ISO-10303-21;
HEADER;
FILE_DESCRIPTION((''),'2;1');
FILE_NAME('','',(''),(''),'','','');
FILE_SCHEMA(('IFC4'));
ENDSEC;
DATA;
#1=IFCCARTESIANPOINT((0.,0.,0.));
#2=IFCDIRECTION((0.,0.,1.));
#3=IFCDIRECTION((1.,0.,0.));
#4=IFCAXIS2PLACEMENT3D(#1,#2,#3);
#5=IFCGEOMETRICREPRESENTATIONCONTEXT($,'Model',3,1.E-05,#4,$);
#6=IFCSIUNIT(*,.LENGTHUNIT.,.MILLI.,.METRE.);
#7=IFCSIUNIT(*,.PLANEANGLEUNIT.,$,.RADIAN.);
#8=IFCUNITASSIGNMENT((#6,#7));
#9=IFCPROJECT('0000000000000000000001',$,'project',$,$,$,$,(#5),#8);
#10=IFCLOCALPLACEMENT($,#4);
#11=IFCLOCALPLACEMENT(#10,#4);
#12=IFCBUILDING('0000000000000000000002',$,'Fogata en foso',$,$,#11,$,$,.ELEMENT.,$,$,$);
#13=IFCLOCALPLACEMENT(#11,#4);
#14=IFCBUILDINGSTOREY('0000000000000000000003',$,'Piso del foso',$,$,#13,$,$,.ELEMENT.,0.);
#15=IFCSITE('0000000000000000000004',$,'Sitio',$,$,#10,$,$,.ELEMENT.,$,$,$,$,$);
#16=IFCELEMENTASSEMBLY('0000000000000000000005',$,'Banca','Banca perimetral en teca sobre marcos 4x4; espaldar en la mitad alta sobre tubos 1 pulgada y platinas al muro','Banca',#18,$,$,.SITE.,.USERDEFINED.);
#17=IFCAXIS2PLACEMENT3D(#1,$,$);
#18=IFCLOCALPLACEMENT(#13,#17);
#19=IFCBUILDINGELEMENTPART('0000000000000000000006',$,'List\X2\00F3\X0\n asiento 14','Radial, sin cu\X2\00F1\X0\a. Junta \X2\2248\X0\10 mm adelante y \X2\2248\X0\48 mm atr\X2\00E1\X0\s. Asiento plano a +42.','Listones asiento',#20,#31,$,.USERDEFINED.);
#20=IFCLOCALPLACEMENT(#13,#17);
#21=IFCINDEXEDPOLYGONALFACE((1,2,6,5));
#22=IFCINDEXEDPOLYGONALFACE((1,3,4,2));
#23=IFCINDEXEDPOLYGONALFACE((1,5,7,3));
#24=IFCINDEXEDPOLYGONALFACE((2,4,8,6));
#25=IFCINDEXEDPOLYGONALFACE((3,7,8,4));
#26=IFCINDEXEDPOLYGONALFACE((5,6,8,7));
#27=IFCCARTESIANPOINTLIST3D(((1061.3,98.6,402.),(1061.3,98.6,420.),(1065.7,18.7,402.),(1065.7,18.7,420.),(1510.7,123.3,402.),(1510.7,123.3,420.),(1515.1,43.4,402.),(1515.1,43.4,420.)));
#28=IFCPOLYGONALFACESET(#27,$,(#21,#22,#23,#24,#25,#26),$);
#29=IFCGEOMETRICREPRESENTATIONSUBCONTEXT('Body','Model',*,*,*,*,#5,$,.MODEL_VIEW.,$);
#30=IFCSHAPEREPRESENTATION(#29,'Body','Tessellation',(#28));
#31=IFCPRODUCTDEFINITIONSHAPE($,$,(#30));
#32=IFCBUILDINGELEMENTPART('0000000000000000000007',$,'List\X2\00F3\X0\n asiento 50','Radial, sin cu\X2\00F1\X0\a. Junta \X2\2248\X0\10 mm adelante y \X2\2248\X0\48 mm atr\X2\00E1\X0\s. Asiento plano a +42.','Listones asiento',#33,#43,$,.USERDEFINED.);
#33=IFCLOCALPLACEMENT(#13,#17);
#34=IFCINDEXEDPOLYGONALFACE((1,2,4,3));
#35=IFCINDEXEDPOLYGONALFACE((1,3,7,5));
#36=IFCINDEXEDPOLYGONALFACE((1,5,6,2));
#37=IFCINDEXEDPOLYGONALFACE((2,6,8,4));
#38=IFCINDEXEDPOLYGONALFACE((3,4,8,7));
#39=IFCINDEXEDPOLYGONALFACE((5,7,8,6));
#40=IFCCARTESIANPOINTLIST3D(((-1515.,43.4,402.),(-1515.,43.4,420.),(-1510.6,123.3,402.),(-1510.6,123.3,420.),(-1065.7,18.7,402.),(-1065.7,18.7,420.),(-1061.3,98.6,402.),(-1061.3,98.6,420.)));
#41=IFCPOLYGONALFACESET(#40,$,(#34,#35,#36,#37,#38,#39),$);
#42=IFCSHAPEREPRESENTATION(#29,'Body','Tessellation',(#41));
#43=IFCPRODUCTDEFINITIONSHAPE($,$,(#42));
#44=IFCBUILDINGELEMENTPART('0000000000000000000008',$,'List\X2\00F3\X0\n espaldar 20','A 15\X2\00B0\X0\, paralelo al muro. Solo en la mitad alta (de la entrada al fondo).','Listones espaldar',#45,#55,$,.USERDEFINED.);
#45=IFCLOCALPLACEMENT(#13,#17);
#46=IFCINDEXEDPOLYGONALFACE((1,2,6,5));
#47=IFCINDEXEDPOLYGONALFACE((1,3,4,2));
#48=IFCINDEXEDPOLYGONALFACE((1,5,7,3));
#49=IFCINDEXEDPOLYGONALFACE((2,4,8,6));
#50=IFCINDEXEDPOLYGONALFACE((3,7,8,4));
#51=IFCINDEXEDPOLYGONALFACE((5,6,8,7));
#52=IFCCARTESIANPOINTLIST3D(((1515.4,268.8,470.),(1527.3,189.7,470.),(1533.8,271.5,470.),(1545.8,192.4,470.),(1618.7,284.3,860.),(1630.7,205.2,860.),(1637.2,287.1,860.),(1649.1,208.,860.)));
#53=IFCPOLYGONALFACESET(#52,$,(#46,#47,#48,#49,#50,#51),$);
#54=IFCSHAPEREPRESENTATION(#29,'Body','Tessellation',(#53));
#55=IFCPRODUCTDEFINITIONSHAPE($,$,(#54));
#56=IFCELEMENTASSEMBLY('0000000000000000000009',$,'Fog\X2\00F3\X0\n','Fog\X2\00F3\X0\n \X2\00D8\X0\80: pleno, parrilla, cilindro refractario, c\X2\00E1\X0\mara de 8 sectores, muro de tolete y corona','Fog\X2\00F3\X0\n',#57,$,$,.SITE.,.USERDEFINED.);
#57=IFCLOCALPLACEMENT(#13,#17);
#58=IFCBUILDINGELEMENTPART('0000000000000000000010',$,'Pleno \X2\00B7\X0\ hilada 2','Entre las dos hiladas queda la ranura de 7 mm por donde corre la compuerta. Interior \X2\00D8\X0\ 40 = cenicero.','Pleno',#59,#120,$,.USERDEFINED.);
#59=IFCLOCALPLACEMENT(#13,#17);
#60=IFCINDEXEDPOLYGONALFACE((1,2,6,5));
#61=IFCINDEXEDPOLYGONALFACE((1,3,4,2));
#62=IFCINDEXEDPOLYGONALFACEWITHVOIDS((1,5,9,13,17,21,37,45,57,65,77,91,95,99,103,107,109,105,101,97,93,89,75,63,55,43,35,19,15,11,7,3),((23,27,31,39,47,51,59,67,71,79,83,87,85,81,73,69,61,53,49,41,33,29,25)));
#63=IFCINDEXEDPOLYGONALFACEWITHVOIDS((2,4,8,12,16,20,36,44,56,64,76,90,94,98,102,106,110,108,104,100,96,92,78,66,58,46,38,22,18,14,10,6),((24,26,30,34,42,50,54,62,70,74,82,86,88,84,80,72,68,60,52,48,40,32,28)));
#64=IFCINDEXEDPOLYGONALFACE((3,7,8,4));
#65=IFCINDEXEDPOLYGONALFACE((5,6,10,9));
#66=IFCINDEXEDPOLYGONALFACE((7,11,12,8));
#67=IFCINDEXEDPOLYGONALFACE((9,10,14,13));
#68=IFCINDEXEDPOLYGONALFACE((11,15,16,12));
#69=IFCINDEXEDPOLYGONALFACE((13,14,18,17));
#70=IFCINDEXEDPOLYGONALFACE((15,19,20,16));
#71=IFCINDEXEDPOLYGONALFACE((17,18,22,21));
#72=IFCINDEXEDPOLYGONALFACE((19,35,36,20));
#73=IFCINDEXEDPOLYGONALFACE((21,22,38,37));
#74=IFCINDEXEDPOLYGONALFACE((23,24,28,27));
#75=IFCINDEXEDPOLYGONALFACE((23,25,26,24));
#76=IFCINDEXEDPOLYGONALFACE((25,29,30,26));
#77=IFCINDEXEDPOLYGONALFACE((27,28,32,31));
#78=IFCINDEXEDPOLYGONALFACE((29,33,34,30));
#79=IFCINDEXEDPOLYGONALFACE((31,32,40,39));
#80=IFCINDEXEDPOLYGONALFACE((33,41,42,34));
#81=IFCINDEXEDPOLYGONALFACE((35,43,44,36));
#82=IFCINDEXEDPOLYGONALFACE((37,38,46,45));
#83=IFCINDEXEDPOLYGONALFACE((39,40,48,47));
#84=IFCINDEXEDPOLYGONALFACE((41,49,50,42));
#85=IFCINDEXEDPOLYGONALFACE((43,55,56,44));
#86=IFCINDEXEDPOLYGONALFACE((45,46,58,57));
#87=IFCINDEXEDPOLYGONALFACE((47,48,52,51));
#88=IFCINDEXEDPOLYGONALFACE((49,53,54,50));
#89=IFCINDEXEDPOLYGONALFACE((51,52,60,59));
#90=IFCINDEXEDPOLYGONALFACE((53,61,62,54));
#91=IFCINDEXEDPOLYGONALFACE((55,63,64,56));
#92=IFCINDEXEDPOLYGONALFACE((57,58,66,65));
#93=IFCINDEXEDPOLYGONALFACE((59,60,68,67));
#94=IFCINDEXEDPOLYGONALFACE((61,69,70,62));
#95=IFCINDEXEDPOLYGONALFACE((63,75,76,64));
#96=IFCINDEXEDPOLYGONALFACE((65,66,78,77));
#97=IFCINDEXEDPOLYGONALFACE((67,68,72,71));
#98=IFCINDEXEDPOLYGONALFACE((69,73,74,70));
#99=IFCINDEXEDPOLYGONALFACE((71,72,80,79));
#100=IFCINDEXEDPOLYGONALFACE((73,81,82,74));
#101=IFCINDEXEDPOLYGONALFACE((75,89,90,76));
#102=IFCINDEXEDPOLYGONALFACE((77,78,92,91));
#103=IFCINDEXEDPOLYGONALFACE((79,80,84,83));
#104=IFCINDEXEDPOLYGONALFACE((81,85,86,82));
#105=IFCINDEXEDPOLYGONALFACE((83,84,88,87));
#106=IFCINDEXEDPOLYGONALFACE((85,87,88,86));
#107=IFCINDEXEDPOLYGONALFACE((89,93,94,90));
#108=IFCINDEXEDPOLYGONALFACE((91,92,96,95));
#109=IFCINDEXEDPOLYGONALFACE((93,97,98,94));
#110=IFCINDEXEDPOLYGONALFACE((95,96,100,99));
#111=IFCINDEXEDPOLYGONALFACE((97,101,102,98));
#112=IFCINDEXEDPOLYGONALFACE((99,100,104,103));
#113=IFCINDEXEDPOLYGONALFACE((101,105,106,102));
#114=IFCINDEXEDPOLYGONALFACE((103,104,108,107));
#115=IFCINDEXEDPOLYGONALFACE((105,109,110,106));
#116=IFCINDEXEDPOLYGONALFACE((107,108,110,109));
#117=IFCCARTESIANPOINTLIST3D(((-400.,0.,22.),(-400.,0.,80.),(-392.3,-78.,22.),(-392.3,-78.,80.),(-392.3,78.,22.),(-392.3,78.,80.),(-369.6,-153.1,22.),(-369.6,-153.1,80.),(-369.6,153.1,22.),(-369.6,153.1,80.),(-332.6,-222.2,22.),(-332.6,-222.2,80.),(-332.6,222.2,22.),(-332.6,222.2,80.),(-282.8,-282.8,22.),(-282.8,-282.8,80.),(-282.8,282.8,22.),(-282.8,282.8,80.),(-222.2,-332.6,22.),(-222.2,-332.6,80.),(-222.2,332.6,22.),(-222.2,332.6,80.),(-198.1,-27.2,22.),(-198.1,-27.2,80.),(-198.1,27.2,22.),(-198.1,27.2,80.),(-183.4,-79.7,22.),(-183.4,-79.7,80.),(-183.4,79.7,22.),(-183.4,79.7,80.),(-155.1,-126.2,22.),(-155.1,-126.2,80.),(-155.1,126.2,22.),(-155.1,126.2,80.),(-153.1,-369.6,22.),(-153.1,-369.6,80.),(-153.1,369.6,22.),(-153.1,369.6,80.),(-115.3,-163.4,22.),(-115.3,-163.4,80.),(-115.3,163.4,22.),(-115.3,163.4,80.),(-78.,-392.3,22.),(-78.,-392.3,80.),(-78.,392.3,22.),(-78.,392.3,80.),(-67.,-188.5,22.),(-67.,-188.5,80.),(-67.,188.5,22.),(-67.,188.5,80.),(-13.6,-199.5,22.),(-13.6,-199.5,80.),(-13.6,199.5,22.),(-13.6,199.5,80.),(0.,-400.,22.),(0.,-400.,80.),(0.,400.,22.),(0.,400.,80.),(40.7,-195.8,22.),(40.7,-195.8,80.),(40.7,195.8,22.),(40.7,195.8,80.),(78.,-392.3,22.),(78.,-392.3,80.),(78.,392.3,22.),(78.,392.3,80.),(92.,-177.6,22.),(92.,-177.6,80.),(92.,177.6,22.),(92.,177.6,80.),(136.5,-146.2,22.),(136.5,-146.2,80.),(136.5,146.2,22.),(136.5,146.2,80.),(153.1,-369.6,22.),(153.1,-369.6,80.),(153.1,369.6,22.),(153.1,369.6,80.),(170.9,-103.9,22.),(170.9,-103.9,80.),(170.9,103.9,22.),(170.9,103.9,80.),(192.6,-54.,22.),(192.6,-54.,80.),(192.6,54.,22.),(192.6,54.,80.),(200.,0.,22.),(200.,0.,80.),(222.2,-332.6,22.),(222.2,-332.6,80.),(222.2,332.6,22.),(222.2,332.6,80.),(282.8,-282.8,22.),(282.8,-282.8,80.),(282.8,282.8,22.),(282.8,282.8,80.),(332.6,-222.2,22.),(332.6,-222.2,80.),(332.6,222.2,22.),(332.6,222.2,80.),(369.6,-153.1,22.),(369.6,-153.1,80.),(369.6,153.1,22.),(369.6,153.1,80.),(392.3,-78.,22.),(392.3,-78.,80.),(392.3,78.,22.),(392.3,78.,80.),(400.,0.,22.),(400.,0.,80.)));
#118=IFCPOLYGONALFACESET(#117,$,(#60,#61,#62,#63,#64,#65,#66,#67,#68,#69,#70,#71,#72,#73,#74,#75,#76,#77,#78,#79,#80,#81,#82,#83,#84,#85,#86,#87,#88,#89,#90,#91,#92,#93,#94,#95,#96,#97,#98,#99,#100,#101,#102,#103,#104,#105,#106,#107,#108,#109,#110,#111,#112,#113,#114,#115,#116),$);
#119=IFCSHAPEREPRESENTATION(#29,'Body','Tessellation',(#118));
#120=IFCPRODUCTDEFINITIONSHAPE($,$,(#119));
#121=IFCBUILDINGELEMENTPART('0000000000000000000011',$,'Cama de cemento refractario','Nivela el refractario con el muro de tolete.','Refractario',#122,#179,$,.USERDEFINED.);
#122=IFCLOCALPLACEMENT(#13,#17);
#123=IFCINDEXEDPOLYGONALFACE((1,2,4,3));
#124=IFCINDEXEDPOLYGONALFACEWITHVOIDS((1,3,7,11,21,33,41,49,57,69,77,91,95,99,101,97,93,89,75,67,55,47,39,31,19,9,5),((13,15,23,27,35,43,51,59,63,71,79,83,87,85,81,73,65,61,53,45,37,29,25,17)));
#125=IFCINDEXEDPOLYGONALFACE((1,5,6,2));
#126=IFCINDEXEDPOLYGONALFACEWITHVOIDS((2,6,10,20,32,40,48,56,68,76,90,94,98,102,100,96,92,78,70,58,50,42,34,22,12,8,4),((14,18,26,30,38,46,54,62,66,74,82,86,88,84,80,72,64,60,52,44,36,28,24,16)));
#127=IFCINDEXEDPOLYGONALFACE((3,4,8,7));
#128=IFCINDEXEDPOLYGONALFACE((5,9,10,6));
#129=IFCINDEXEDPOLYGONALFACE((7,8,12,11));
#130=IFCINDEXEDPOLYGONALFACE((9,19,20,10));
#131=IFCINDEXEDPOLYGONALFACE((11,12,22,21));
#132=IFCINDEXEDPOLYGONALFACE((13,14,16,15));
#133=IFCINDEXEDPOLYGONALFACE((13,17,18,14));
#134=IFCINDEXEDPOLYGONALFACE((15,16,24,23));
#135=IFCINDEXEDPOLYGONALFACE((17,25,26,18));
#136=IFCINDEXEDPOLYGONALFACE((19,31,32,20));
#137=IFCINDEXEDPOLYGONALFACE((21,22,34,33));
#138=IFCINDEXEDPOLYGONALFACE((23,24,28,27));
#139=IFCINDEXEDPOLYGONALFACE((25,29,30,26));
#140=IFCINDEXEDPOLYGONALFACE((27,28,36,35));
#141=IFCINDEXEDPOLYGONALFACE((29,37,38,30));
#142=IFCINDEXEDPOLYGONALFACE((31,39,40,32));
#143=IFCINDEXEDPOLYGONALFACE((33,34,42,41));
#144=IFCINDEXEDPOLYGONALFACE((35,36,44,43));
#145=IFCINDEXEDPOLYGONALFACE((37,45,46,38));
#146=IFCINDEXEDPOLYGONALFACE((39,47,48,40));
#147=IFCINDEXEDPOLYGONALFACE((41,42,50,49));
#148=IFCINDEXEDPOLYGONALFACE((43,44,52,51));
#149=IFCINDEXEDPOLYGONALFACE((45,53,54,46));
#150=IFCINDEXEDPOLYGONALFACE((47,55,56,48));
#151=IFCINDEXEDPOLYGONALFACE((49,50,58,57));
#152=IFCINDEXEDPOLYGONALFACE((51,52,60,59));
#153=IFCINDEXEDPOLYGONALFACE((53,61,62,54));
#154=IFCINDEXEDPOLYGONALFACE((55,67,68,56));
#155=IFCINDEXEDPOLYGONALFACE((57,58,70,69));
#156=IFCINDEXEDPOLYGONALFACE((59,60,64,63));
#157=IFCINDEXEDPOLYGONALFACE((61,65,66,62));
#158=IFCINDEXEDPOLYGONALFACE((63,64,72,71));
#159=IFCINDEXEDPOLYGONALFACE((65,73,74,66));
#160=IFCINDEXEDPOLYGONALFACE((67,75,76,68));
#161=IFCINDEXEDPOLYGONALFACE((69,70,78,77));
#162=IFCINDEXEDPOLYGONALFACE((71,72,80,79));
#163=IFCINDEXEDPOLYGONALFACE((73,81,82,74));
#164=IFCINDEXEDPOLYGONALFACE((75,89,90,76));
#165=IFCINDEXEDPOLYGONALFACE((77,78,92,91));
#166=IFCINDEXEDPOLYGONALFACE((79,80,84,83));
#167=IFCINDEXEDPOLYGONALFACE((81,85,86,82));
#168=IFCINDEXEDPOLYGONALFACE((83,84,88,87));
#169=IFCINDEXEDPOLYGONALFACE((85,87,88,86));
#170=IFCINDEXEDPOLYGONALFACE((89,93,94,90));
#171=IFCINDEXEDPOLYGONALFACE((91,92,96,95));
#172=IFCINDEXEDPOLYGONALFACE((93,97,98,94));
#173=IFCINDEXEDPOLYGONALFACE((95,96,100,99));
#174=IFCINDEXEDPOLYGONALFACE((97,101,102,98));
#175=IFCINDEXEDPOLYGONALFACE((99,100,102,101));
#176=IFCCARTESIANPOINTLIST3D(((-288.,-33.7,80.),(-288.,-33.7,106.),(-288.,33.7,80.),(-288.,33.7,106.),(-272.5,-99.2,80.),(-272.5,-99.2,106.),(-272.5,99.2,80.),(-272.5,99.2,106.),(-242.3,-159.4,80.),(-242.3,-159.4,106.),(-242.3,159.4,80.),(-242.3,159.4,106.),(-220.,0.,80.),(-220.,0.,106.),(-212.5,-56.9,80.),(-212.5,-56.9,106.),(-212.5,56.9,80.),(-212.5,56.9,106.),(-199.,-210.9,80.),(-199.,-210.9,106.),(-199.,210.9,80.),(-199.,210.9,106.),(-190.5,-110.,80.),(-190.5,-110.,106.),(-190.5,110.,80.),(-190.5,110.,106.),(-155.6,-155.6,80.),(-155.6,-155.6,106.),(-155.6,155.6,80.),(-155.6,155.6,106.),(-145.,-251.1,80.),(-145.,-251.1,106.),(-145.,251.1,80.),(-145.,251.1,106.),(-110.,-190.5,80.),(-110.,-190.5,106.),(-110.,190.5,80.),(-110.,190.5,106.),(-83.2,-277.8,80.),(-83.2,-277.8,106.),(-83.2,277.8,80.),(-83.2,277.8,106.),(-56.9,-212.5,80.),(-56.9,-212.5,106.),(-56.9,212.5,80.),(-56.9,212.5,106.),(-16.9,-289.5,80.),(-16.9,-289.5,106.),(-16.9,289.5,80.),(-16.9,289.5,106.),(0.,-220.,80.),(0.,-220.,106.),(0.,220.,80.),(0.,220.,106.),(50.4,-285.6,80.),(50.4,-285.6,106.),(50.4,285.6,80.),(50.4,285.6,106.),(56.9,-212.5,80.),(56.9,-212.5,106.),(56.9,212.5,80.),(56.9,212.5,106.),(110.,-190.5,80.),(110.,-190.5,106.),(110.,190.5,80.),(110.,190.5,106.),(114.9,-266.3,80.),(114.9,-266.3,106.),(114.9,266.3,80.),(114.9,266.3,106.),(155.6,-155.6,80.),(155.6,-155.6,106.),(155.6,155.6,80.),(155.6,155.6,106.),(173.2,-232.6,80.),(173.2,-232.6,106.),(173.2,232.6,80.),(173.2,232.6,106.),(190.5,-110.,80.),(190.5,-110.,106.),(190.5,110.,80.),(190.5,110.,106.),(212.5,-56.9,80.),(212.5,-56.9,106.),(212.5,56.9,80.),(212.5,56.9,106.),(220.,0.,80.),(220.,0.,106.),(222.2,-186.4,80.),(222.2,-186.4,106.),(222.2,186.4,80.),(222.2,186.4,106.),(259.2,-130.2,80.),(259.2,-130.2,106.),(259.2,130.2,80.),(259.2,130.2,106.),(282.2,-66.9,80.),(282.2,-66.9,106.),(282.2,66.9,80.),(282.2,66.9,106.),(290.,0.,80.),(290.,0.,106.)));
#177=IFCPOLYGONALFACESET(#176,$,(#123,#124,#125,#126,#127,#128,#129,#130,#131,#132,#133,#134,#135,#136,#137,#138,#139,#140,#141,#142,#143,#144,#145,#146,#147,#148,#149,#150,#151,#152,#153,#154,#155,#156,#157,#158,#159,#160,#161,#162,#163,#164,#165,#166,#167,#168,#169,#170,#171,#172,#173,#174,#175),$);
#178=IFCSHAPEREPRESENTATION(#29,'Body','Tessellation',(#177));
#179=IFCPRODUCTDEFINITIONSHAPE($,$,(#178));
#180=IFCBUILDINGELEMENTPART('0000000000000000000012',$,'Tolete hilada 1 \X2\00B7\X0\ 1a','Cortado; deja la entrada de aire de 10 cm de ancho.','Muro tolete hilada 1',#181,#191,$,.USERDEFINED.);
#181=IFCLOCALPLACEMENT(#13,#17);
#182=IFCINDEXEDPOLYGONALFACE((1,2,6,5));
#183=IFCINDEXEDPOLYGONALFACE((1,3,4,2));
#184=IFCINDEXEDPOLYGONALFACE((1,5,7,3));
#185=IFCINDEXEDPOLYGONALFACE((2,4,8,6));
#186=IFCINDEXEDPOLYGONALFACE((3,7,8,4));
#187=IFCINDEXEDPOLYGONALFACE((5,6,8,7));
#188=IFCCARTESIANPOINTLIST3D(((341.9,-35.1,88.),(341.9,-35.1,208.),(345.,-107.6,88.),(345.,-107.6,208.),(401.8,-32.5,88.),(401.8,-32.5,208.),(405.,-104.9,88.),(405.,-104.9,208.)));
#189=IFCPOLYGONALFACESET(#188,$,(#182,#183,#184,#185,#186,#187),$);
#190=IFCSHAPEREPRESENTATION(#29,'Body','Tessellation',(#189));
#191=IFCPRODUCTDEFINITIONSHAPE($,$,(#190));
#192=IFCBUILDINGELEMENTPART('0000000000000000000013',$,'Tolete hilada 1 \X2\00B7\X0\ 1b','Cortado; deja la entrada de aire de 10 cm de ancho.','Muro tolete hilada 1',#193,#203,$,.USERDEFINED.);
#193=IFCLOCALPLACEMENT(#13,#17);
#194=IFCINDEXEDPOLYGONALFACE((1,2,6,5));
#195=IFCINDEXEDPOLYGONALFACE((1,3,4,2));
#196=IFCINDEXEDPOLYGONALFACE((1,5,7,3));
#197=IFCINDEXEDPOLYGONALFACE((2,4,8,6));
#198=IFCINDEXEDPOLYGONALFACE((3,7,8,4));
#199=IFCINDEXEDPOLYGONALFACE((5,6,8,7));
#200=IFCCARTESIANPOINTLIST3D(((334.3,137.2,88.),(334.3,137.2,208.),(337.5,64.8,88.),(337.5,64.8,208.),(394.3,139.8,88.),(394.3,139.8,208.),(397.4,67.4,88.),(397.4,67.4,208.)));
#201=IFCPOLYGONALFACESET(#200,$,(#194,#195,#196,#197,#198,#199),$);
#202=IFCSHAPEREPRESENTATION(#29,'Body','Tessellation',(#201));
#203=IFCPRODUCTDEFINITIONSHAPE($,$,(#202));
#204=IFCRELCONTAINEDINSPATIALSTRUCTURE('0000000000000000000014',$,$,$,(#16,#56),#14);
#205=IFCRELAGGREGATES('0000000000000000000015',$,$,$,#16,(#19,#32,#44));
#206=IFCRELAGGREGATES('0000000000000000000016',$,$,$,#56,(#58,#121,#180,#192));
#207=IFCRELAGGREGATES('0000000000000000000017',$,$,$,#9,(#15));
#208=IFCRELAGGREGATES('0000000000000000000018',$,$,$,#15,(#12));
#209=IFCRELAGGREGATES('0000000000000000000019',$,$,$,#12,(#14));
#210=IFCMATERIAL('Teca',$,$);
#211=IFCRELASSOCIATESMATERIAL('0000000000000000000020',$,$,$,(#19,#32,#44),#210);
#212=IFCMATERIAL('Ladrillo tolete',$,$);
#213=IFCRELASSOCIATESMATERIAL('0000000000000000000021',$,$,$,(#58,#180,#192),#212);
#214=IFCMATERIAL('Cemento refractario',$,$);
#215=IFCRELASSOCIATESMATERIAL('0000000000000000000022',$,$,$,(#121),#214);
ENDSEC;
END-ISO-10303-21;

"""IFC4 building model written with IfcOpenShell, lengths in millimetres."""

from ifc_helpers import new_model, si_unit, frame, origin_with_axes, origin_2d, place, context, subcontext, project, spatial, polyline, hollow_circle, outline, extrude, material, element, aggregate, save


model = new_model("IFC4")

# Units and contexts
model_context = context("Model", 3, precision=1e-05, world=origin_with_axes())
body_context = subcontext(model_context, "Body", "Model", "MODEL_VIEW")
ifc_project = project(units=[si_unit("LENGTHUNIT", "METRE", prefix="MILLI"), si_unit("PLANEANGLEUNIT", "RADIAN")], contexts=[model_context])

# Site, building, storey
site_placement = place(None, origin_with_axes())
site = spatial("IfcSite", under=ifc_project, at=site_placement, Name="Sitio", CompositionType="ELEMENT")
building_placement = place(site_placement, origin_with_axes())
building = spatial("IfcBuilding", under=site, at=building_placement, Name="Fogata en foso", CompositionType="ELEMENT")
storey_placement = place(building_placement, origin_with_axes())
storey = spatial("IfcBuildingStorey", under=building, at=storey_placement, Name="Piso del foso", CompositionType="ELEMENT", Elevation=0.0)

# Element assembly, building element parts
assembly_1_placement = place(storey_placement, origin_with_axes())
assembly_1 = element("IfcElementAssembly", 1, at=assembly_1_placement, inside=storey, Name="Banca", Description="Banca perimetral en teca sobre marcos 4x4; espaldar en la mitad alta sobre tubos 1 pulgada y platinas al muro", ObjectType="Banca", AssemblyPlace="SITE", PredefinedType="USERDEFINED")
ifc_material_1 = material(Name="Teca")
building_element_part_1_placement = place(storey_placement, frame((-2.2, 39.9, 0.0), z_axis=(0.055, -0.998, 0.0), x_axis=(0.998, 0.055, 0.0)))
building_element_part_1 = element("IfcBuildingElementPart", 2, at=building_element_part_1_placement, material=ifc_material_1, Name="Listón asiento 14", Description="Radial, sin cuña. Junta ≈10 mm adelante y ≈48 mm atrás. Asiento plano a +42.", ObjectType="Listones asiento", PredefinedType="USERDEFINED", context=body_context, shape_type="SweptSolid", body=[
    extrude(outline(polyline([(1065.1, 402.0), (1515.1, 402.0), (1515.1, 420.0), (1065.1, 420.0), (1065.1, 402.0)])), origin_with_axes(), (0.0, 0.0, 1.0), 80.0),
])
building_element_part_2_placement = place(storey_placement, frame((-2.2, -39.9, 0.0), z_axis=(0.055, 0.998, 0.0), x_axis=(-0.998, 0.055, 0.0)))
building_element_part_2 = element("IfcBuildingElementPart", 3, at=building_element_part_2_placement, material=ifc_material_1, Name="Listón asiento 50", Description="Radial, sin cuña. Junta ≈10 mm adelante y ≈48 mm atrás. Asiento plano a +42.", ObjectType="Listones asiento", PredefinedType="USERDEFINED", context=body_context, shape_type="SweptSolid", body=[
    extrude(outline(polyline([(1065.1, 402.0), (1515.1, 402.0), (1515.1, 420.0), (1065.1, 420.0), (1065.1, 402.0)])), origin_with_axes(), (0.0, 0.0, 1.0), 80.0),
])
building_element_part_3_placement = place(storey_placement, frame((-6.0, 39.6, 0.0), z_axis=(0.149, -0.989, 0.0), x_axis=(0.989, 0.149, 0.0)))
building_element_part_3 = element("IfcBuildingElementPart", 4, at=building_element_part_3_placement, material=ifc_material_1, Name="Listón espaldar 20", Description="A 15°, paralelo al muro. Solo en la mitad alta (de la entrada al fondo).", ObjectType="Listones espaldar", PredefinedType="USERDEFINED", context=body_context, shape_type="SweptSolid", body=[
    extrude(outline(polyline([(1538.5, 470.0), (1557.2, 470.0), (1661.7, 860.0), (1643.0, 860.0), (1538.5, 470.0)])), origin_with_axes(), (0.0, 0.0, 1.0), 80.0),
])
aggregate(assembly_1, [building_element_part_1, building_element_part_2, building_element_part_3])

# Element assembly, building element parts
assembly_2_placement = place(storey_placement, origin_with_axes())
assembly_2 = element("IfcElementAssembly", 5, at=assembly_2_placement, inside=storey, Name="Fogón", Description="Fogón Ø80: pleno, parrilla, cilindro refractario, cámara de 8 sectores, muro de tolete y corona", ObjectType="Fogón", AssemblyPlace="SITE", PredefinedType="USERDEFINED")
ifc_material_2 = material(Name="Ladrillo tolete")
building_element_part_4_placement = place(storey_placement, frame((0.0, 0.0, 22.0), z_axis=(0.0, 0.0, 1.0), x_axis=(1.0, 0.0, 0.0)))
building_element_part_4 = element("IfcBuildingElementPart", 6, at=building_element_part_4_placement, material=ifc_material_2, Name="Pleno · hilada 2", Description="Entre las dos hiladas queda la ranura de 7 mm por donde corre la compuerta. Interior Ø 40 = cenicero.", ObjectType="Pleno", PredefinedType="USERDEFINED", context=body_context, shape_type="SweptSolid", body=[
    extrude(hollow_circle(Radius=400.0, WallThickness=200.0, at=origin_2d()), origin_with_axes(), (0.0, 0.0, 1.0), 58.0),
])
ifc_material_3 = material(Name="Cemento refractario")
building_element_part_5_placement = place(storey_placement, frame((0.0, 0.0, 80.0), z_axis=(0.0, 0.0, 1.0), x_axis=(1.0, 0.0, 0.0)))
building_element_part_5 = element("IfcBuildingElementPart", 7, at=building_element_part_5_placement, material=ifc_material_3, Name="Cama de cemento refractario", Description="Nivela el refractario con el muro de tolete.", ObjectType="Refractario", PredefinedType="USERDEFINED", context=body_context, shape_type="SweptSolid", body=[
    extrude(hollow_circle(Radius=290.0, WallThickness=70.0, at=origin_2d()), origin_with_axes(), (0.0, 0.0, 1.0), 26.0),
])
building_element_part_6_placement = place(storey_placement, frame((0.0, 0.0, 88.0), z_axis=(0.0, 0.0, 1.0), x_axis=(1.0, 0.0, 0.0)))
building_element_part_6 = element("IfcBuildingElementPart", 8, at=building_element_part_6_placement, material=ifc_material_2, Name="Tolete hilada 1 · 1a", Description="Cortado; deja la entrada de aire de 10 cm de ancho.", ObjectType="Muro tolete hilada 1", PredefinedType="USERDEFINED", context=body_context, shape_type="SweptSolid", body=[
    extrude(outline(polyline([(405.0, -104.9), (401.8, -32.5), (341.9, -35.1), (345.0, -107.6), (405.0, -104.9)])), origin_with_axes(), (0.0, 0.0, 1.0), 120.0),
])
building_element_part_7_placement = place(storey_placement, frame((0.0, 0.0, 88.0), z_axis=(0.0, 0.0, 1.0), x_axis=(1.0, 0.0, 0.0)))
building_element_part_7 = element("IfcBuildingElementPart", 9, at=building_element_part_7_placement, material=ifc_material_2, Name="Tolete hilada 1 · 1b", Description="Cortado; deja la entrada de aire de 10 cm de ancho.", ObjectType="Muro tolete hilada 1", PredefinedType="USERDEFINED", context=body_context, shape_type="SweptSolid", body=[
    extrude(outline(polyline([(397.4, 67.4), (394.3, 139.8), (334.3, 137.2), (337.5, 64.8), (397.4, 67.4)])), origin_with_axes(), (0.0, 0.0, 1.0), 120.0),
])
aggregate(assembly_2, [building_element_part_4, building_element_part_5, building_element_part_6, building_element_part_7])

save(model, "model.ifc")
